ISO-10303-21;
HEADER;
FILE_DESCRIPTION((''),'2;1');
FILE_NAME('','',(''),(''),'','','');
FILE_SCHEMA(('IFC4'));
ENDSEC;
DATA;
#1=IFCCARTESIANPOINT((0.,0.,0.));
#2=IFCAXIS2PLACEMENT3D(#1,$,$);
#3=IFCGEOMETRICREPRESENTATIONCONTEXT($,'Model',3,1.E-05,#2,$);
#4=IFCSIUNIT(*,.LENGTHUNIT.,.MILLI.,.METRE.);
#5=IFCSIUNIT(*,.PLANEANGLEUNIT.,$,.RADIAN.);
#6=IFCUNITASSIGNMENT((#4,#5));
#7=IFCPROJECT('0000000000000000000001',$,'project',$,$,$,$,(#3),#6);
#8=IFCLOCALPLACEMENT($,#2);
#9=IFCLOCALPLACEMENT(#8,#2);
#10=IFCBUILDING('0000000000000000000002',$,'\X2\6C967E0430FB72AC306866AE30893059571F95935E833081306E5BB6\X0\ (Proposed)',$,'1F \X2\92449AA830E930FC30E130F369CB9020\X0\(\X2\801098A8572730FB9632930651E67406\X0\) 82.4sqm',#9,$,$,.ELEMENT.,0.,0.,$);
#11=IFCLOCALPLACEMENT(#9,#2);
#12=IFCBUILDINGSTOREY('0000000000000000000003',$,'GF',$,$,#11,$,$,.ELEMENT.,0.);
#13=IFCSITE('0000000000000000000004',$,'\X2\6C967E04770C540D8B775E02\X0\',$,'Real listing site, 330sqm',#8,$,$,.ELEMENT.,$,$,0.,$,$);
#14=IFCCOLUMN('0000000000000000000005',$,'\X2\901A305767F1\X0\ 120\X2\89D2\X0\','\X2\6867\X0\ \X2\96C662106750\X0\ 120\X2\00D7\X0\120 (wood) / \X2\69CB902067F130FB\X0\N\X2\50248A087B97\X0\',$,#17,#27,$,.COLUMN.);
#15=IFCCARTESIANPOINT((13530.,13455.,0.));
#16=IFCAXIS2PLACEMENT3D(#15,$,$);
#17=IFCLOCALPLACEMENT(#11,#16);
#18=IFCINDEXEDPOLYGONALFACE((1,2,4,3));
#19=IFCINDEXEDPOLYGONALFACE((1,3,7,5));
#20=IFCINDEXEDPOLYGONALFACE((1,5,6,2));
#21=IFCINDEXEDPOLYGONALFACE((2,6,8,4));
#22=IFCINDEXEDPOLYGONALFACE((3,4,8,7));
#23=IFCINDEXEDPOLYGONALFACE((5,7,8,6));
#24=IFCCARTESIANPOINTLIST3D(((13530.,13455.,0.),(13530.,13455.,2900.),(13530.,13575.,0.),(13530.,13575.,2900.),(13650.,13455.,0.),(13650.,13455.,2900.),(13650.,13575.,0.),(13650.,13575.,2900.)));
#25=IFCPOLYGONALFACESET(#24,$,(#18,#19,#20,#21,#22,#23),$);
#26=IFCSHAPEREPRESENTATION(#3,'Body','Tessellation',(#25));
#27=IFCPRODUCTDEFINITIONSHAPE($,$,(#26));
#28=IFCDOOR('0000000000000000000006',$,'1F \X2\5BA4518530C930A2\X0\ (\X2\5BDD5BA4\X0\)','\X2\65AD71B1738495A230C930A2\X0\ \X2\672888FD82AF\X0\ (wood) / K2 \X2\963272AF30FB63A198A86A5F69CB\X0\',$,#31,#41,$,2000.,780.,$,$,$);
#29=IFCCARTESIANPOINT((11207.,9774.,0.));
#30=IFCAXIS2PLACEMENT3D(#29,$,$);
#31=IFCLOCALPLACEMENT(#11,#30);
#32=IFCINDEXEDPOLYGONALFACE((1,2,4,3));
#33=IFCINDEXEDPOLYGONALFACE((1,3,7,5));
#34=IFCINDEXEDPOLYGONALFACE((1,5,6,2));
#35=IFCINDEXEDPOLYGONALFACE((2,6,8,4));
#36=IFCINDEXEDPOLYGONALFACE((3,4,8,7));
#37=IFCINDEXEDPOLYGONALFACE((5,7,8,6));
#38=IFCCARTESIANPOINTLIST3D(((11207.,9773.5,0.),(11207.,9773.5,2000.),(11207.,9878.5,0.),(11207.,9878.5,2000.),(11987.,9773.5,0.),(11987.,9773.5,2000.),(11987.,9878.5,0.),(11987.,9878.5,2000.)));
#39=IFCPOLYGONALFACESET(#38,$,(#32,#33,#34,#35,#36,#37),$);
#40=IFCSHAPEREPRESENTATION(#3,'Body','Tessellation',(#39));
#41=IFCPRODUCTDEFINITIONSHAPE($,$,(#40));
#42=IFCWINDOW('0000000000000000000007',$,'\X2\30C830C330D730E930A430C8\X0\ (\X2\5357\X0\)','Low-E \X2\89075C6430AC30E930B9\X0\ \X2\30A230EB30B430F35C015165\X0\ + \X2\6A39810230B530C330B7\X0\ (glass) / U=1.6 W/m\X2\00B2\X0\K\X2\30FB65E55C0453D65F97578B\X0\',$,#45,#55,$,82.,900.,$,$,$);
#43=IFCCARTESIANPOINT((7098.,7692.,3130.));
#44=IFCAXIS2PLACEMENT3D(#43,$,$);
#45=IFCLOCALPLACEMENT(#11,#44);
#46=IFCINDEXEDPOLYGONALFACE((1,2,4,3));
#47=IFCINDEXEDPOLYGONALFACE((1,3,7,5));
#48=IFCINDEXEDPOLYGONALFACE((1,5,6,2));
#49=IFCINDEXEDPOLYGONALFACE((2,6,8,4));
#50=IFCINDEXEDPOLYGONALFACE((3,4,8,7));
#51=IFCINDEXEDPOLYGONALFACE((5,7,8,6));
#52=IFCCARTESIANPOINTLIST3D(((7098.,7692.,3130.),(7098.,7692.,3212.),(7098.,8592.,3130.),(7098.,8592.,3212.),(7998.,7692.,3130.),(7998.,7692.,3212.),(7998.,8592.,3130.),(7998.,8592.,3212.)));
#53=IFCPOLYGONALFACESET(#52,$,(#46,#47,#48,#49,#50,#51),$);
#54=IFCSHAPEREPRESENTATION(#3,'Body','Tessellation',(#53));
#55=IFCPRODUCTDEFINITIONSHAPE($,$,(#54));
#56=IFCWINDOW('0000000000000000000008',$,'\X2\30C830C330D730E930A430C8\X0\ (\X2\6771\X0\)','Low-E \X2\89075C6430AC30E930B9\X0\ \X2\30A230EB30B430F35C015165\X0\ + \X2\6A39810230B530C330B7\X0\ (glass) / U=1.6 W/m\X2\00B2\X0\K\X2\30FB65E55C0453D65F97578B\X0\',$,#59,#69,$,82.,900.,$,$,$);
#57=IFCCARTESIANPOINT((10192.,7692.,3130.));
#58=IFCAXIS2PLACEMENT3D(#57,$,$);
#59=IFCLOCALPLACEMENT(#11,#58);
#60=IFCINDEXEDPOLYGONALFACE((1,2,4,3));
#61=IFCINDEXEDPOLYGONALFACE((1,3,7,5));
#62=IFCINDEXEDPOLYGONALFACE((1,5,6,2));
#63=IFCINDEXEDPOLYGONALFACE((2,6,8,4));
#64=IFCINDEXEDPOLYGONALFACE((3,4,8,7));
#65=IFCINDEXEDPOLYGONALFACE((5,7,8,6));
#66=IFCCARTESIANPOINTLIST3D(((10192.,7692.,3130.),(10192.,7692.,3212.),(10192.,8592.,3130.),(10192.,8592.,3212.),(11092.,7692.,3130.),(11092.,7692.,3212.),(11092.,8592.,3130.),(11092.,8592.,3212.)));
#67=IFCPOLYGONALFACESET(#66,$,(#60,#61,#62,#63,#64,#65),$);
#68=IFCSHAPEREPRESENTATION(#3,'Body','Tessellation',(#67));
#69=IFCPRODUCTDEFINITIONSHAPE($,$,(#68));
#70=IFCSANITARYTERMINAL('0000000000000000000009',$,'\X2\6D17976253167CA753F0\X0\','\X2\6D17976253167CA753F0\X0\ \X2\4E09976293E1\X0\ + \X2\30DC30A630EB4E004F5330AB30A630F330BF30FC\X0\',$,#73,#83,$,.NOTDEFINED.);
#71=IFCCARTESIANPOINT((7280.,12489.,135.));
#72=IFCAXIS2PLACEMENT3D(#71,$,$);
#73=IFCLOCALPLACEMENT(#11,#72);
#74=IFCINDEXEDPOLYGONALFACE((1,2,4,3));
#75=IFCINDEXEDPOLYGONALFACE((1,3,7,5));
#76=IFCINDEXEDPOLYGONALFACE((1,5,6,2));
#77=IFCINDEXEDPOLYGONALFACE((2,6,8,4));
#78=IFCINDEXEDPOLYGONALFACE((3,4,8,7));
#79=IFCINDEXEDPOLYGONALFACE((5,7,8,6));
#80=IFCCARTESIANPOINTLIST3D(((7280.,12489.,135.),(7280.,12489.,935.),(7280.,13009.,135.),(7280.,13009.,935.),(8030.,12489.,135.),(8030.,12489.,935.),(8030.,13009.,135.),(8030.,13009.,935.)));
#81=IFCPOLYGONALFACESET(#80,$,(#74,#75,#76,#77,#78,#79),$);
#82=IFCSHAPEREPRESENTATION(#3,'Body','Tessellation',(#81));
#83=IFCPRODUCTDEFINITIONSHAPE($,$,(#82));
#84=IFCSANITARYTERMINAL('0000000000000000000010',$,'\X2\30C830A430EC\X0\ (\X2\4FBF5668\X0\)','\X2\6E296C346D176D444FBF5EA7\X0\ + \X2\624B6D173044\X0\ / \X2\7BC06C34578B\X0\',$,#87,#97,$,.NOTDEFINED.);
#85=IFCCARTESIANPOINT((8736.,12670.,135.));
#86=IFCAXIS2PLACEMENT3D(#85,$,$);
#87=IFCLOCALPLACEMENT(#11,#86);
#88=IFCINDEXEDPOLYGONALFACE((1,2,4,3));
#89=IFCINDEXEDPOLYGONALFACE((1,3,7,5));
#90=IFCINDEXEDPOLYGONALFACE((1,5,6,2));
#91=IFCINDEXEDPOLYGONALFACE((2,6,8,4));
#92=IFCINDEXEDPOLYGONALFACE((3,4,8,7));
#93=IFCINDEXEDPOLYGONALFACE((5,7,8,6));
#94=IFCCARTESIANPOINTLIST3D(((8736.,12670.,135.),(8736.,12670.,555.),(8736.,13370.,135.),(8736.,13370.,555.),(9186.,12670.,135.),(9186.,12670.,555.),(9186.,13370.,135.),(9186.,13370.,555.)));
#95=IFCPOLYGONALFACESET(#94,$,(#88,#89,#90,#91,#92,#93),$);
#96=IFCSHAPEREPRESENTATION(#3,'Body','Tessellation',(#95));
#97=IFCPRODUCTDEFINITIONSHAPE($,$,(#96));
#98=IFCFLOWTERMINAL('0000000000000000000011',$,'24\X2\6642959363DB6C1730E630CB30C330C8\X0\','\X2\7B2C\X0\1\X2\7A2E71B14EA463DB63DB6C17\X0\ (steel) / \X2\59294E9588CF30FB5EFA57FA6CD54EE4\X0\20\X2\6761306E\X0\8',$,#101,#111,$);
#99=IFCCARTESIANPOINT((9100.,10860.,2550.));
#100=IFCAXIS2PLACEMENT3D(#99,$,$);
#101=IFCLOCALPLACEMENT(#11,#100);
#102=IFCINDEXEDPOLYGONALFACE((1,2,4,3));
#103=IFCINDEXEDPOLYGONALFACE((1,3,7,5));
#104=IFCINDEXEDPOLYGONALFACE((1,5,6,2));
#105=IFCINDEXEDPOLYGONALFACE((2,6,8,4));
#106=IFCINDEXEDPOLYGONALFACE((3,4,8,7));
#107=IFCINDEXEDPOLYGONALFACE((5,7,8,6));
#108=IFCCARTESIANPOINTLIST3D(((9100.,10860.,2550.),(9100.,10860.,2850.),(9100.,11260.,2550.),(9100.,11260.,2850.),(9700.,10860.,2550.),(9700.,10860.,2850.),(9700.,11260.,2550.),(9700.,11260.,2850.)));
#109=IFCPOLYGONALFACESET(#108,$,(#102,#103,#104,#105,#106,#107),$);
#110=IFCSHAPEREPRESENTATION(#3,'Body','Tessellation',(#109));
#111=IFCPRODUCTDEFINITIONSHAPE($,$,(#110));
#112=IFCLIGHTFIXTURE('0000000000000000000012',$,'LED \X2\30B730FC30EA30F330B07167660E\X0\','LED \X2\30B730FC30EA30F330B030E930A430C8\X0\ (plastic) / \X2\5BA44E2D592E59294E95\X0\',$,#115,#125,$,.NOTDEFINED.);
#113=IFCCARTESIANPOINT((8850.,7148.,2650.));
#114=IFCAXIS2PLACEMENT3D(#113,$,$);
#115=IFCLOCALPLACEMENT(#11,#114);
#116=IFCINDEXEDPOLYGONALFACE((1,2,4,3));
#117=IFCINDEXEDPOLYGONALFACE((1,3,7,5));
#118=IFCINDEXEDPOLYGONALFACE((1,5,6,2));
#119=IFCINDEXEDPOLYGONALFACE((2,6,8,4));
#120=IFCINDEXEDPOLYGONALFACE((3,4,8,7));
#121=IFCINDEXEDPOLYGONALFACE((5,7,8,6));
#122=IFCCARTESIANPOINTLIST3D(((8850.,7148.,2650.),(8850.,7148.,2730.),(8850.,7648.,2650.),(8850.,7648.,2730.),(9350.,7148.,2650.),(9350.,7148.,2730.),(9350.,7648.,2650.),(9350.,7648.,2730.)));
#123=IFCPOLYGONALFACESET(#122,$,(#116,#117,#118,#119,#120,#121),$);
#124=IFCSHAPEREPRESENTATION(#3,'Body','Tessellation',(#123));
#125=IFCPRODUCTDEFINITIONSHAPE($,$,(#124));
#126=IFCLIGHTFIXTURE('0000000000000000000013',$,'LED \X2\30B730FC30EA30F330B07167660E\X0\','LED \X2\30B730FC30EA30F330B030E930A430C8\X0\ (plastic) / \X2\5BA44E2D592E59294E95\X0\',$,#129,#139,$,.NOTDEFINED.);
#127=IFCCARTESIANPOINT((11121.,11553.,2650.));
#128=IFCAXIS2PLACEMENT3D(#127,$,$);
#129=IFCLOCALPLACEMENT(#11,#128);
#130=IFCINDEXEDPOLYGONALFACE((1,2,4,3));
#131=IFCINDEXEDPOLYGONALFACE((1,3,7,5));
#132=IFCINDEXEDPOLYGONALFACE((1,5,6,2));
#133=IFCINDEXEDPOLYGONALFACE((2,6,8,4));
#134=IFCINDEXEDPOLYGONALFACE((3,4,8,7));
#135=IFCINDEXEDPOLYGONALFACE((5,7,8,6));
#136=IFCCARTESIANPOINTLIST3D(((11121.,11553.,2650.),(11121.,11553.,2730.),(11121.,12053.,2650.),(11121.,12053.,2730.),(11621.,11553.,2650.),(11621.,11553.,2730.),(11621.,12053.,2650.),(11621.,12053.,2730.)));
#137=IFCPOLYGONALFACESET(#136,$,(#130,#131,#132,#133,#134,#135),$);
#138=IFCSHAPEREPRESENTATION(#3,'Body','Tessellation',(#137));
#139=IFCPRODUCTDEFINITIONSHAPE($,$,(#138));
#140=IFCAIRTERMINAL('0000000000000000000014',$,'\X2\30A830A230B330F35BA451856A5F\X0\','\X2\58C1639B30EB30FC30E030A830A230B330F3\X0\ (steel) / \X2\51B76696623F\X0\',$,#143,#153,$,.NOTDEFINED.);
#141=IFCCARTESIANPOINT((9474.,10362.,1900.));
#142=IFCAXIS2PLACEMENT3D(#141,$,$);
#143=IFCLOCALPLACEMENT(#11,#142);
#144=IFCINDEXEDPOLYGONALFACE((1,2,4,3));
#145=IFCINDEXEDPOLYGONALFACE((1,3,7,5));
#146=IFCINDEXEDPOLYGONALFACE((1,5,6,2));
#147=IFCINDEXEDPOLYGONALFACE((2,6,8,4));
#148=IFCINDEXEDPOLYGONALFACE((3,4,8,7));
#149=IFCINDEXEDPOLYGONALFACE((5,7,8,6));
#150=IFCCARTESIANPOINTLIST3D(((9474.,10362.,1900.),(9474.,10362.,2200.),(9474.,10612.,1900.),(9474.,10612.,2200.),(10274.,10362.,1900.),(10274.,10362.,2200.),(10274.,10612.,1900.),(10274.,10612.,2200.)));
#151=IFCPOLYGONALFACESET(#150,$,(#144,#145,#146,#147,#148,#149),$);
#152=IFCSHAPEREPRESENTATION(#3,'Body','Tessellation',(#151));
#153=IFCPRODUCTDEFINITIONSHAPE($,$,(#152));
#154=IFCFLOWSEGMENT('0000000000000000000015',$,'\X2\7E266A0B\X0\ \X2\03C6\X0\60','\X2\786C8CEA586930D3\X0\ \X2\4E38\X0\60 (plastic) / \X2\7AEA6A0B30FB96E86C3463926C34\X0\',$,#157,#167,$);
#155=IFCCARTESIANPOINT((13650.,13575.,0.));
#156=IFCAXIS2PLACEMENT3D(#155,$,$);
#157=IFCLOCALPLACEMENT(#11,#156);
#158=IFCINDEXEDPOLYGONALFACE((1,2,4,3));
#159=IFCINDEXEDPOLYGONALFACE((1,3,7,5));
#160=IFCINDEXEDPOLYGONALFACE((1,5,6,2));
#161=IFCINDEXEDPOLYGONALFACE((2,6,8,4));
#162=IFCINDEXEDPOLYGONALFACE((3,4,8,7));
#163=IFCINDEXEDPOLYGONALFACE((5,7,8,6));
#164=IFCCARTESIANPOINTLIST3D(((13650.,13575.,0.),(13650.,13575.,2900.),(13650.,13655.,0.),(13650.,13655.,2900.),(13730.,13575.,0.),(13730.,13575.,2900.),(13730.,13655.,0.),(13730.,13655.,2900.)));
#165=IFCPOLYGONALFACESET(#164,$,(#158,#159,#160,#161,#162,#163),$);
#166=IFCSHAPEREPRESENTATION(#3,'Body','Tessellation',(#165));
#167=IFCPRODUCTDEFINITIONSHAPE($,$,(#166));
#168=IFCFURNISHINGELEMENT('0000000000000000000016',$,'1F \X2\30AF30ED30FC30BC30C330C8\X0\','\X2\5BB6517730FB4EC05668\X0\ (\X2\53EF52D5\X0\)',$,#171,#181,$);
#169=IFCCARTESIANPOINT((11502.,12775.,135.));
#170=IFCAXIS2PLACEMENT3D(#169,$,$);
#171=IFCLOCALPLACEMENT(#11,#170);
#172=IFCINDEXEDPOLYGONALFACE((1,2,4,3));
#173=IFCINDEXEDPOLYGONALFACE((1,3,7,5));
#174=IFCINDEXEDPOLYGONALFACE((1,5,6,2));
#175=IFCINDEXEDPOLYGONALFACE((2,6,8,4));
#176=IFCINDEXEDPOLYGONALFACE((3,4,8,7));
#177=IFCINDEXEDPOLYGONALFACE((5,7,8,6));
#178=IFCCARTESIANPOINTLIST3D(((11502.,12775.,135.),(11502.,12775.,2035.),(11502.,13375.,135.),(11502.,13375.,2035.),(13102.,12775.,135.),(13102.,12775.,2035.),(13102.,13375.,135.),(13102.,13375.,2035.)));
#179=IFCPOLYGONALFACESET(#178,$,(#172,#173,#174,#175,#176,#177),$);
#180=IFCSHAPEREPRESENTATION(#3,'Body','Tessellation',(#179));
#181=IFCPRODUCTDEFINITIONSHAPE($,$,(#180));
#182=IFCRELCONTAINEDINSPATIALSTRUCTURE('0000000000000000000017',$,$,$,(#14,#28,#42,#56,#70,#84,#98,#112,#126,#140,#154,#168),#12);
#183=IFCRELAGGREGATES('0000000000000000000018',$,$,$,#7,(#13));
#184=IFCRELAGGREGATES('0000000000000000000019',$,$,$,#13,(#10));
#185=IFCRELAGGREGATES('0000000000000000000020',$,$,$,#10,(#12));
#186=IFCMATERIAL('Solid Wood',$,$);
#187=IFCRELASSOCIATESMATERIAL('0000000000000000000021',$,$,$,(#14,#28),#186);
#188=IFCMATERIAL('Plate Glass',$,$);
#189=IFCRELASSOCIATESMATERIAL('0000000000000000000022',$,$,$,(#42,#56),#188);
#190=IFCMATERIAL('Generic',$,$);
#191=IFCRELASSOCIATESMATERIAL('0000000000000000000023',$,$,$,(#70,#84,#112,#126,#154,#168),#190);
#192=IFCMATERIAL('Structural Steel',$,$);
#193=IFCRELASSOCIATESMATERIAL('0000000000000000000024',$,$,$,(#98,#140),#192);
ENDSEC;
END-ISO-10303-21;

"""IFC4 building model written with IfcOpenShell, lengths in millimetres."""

from ifc_helpers import new_model, si_unit, frame, frame_2d, origin, place, context, project, spatial, rectangle, extrude, material, element, save


model = new_model("IFC4")

# Units and contexts
model_context = context("Model", 3, precision=1e-05, world=origin())
ifc_project = project(units=[si_unit("LENGTHUNIT", "METRE", prefix="MILLI"), si_unit("PLANEANGLEUNIT", "RADIAN")], contexts=[model_context])

# Site, building, storey
site_placement = place(None, origin())
site = spatial("IfcSite", under=ifc_project, at=site_placement, Name="沖縄県名護市", ObjectType="Real listing site, 330sqm", CompositionType="ELEMENT", RefElevation=0.0)
building_placement = place(site_placement, origin())
building = spatial("IfcBuilding", under=site, at=building_placement, Name="沖縄・犬と暮らす土間広めの家 (Proposed)", ObjectType="1F 鉄骨ラーメン構造(耐風圧・防錆処理) 82.4sqm", CompositionType="ELEMENT", ElevationOfRefHeight=0.0, ElevationOfTerrain=0.0)
storey_placement = place(building_placement, origin())
storey = spatial("IfcBuildingStorey", under=building, at=storey_placement, Name="GF", CompositionType="ELEMENT", Elevation=0.0)

# Column
ifc_material_1 = material(Name="Solid Wood")
column_1_placement = place(storey_placement, frame((13530.0, 13455.0, 0.0)))
element("IfcColumn", 1, at=column_1_placement, inside=storey, material=ifc_material_1, Name="通し柱 120角", Description="桧 集成材 120×120 (wood) / 構造柱・N値計算", PredefinedType="COLUMN", context=model_context, shape_type="SweptSolid", body=[
    extrude(rectangle(XDim=120.0, YDim=120.0, at=frame_2d((60.0, 60.0))), frame((13530.0, 13455.0, 0.0)), (0.0, 0.0, 1.0), 2900.0),
])

# Door
door_placement = place(storey_placement, frame((11207.0, 9774.0, 0.0)))
element("IfcDoor", 2, at=door_placement, inside=storey, material=ifc_material_1, Name="1F 室内ドア (寝室)", Description="断熱玄関ドア 木製芯 (wood) / K2 防犯・採風機構", OverallHeight=2000.0, OverallWidth=780.0, context=model_context, shape_type="SweptSolid", body=[
    extrude(rectangle(XDim=780.0, YDim=105.0, at=frame_2d((390.0, 52.0))), frame((11207.0, 9774.0, 0.0)), (0.0, 0.0, 1.0), 2000.0),
])

# Windows
ifc_material_2 = material(Name="Plate Glass")
window_1_placement = place(storey_placement, frame((7098.0, 7692.0, 3130.0)))
element("IfcWindow", 3, at=window_1_placement, inside=storey, material=ifc_material_2, Name="トップライト (南)", Description="Low-E 複層ガラス アルゴン封入 + 樹脂サッシ (glass) / U=1.6 W/m²K・日射取得型", OverallHeight=82.0, OverallWidth=900.0, context=model_context, shape_type="SweptSolid", body=[
    extrude(rectangle(XDim=900.0, YDim=900.0, at=frame_2d((450.0, 450.0))), frame((7098.0, 7692.0, 3130.0)), (0.0, 0.0, 1.0), 82.0),
])
window_2_placement = place(storey_placement, frame((10192.0, 7692.0, 3130.0)))
element("IfcWindow", 4, at=window_2_placement, inside=storey, material=ifc_material_2, Name="トップライト (東)", Description="Low-E 複層ガラス アルゴン封入 + 樹脂サッシ (glass) / U=1.6 W/m²K・日射取得型", OverallHeight=82.0, OverallWidth=900.0, context=model_context, shape_type="SweptSolid", body=[
    extrude(rectangle(XDim=900.0, YDim=900.0, at=frame_2d((450.0, 450.0))), frame((10192.0, 7692.0, 3130.0)), (0.0, 0.0, 1.0), 82.0),
])

# Sanitary terminals
ifc_material_3 = material(Name="Generic")
sanitary_terminal_1_placement = place(storey_placement, frame((7280.0, 12489.0, 135.0)))
element("IfcSanitaryTerminal", 5, at=sanitary_terminal_1_placement, inside=storey, material=ifc_material_3, Name="洗面化粧台", Description="洗面化粧台 三面鏡 + ボウル一体カウンター", PredefinedType="NOTDEFINED", context=model_context, shape_type="SweptSolid", body=[
    extrude(rectangle(XDim=750.0, YDim=520.0, at=frame_2d((375.0, 260.0))), frame((7280.0, 12489.0, 135.0)), (0.0, 0.0, 1.0), 800.0),
])
sanitary_terminal_2_placement = place(storey_placement, frame((8736.0, 12670.0, 135.0)))
element("IfcSanitaryTerminal", 6, at=sanitary_terminal_2_placement, inside=storey, material=ifc_material_3, Name="トイレ (便器)", Description="温水洗浄便座 + 手洗い / 節水型", PredefinedType="NOTDEFINED", context=model_context, shape_type="SweptSolid", body=[
    extrude(rectangle(XDim=450.0, YDim=700.0, at=frame_2d((225.0, 350.0))), frame((8736.0, 12670.0, 135.0)), (0.0, 0.0, 1.0), 420.0),
])

# Flow terminal
ifc_material_4 = material(Name="Structural Steel")
flow_terminal_placement = place(storey_placement, frame((9100.0, 10860.0, 2550.0)))
element("IfcFlowTerminal", 7, at=flow_terminal_placement, inside=storey, material=ifc_material_4, Name="24時間換気ユニット", Description="第1種熱交換換気 (steel) / 天井裏・建基法令20条の8", context=model_context, shape_type="SweptSolid", body=[
    extrude(rectangle(XDim=600.0, YDim=400.0, at=frame_2d((300.0, 200.0))), frame((9100.0, 10860.0, 2550.0)), (0.0, 0.0, 1.0), 300.0),
])

# Light fixtures
light_fixture_1_placement = place(storey_placement, frame((8850.0, 7148.0, 2650.0)))
element("IfcLightFixture", 8, at=light_fixture_1_placement, inside=storey, material=ifc_material_3, Name="LED シーリング照明", Description="LED シーリングライト (plastic) / 室中央天井", PredefinedType="NOTDEFINED", context=model_context, shape_type="SweptSolid", body=[
    extrude(rectangle(XDim=500.0, YDim=500.0, at=frame_2d((250.0, 250.0))), frame((8850.0, 7148.0, 2650.0)), (0.0, 0.0, 1.0), 80.0),
])
light_fixture_2_placement = place(storey_placement, frame((11121.0, 11553.0, 2650.0)))
element("IfcLightFixture", 9, at=light_fixture_2_placement, inside=storey, material=ifc_material_3, Name="LED シーリング照明", Description="LED シーリングライト (plastic) / 室中央天井", PredefinedType="NOTDEFINED", context=model_context, shape_type="SweptSolid", body=[
    extrude(rectangle(XDim=500.0, YDim=500.0, at=frame_2d((250.0, 250.0))), frame((11121.0, 11553.0, 2650.0)), (0.0, 0.0, 1.0), 80.0),
])

# Air terminal
air_terminal_placement = place(storey_placement, frame((9474.0, 10362.0, 1900.0)))
element("IfcAirTerminal", 10, at=air_terminal_placement, inside=storey, material=ifc_material_4, Name="エアコン室内機", Description="壁掛ルームエアコン (steel) / 冷暖房", PredefinedType="NOTDEFINED", context=model_context, shape_type="SweptSolid", body=[
    extrude(rectangle(XDim=800.0, YDim=250.0, at=frame_2d((400.0, 125.0))), frame((9474.0, 10362.0, 1900.0)), (0.0, 0.0, 1.0), 300.0),
])

# Flow segment
flow_segment_placement = place(storey_placement, frame((13650.0, 13575.0, 0.0)))
element("IfcFlowSegment", 11, at=flow_segment_placement, inside=storey, material=ifc_material_3, Name="縦樋 φ60", Description="硬質塩ビ 丸60 (plastic) / 竪樋・雨水排水", context=model_context, shape_type="SweptSolid", body=[
    extrude(rectangle(XDim=80.0, YDim=80.0, at=frame_2d((40.0, 40.0))), frame((13650.0, 13575.0, 0.0)), (0.0, 0.0, 1.0), 2900.0),
])

# Furnishing element
furnishing_placement = place(storey_placement, frame((11502.0, 12775.0, 135.0)))
element("IfcFurnishingElement", 12, at=furnishing_placement, inside=storey, material=ifc_material_3, Name="1F クローゼット", Description="家具・什器 (可動)", context=model_context, shape_type="SweptSolid", body=[
    extrude(rectangle(XDim=1600.0, YDim=600.0, at=frame_2d((800.0, 300.0))), frame((11502.0, 12775.0, 135.0)), (0.0, 0.0, 1.0), 1900.0),
])

save(model, "model.ifc")
